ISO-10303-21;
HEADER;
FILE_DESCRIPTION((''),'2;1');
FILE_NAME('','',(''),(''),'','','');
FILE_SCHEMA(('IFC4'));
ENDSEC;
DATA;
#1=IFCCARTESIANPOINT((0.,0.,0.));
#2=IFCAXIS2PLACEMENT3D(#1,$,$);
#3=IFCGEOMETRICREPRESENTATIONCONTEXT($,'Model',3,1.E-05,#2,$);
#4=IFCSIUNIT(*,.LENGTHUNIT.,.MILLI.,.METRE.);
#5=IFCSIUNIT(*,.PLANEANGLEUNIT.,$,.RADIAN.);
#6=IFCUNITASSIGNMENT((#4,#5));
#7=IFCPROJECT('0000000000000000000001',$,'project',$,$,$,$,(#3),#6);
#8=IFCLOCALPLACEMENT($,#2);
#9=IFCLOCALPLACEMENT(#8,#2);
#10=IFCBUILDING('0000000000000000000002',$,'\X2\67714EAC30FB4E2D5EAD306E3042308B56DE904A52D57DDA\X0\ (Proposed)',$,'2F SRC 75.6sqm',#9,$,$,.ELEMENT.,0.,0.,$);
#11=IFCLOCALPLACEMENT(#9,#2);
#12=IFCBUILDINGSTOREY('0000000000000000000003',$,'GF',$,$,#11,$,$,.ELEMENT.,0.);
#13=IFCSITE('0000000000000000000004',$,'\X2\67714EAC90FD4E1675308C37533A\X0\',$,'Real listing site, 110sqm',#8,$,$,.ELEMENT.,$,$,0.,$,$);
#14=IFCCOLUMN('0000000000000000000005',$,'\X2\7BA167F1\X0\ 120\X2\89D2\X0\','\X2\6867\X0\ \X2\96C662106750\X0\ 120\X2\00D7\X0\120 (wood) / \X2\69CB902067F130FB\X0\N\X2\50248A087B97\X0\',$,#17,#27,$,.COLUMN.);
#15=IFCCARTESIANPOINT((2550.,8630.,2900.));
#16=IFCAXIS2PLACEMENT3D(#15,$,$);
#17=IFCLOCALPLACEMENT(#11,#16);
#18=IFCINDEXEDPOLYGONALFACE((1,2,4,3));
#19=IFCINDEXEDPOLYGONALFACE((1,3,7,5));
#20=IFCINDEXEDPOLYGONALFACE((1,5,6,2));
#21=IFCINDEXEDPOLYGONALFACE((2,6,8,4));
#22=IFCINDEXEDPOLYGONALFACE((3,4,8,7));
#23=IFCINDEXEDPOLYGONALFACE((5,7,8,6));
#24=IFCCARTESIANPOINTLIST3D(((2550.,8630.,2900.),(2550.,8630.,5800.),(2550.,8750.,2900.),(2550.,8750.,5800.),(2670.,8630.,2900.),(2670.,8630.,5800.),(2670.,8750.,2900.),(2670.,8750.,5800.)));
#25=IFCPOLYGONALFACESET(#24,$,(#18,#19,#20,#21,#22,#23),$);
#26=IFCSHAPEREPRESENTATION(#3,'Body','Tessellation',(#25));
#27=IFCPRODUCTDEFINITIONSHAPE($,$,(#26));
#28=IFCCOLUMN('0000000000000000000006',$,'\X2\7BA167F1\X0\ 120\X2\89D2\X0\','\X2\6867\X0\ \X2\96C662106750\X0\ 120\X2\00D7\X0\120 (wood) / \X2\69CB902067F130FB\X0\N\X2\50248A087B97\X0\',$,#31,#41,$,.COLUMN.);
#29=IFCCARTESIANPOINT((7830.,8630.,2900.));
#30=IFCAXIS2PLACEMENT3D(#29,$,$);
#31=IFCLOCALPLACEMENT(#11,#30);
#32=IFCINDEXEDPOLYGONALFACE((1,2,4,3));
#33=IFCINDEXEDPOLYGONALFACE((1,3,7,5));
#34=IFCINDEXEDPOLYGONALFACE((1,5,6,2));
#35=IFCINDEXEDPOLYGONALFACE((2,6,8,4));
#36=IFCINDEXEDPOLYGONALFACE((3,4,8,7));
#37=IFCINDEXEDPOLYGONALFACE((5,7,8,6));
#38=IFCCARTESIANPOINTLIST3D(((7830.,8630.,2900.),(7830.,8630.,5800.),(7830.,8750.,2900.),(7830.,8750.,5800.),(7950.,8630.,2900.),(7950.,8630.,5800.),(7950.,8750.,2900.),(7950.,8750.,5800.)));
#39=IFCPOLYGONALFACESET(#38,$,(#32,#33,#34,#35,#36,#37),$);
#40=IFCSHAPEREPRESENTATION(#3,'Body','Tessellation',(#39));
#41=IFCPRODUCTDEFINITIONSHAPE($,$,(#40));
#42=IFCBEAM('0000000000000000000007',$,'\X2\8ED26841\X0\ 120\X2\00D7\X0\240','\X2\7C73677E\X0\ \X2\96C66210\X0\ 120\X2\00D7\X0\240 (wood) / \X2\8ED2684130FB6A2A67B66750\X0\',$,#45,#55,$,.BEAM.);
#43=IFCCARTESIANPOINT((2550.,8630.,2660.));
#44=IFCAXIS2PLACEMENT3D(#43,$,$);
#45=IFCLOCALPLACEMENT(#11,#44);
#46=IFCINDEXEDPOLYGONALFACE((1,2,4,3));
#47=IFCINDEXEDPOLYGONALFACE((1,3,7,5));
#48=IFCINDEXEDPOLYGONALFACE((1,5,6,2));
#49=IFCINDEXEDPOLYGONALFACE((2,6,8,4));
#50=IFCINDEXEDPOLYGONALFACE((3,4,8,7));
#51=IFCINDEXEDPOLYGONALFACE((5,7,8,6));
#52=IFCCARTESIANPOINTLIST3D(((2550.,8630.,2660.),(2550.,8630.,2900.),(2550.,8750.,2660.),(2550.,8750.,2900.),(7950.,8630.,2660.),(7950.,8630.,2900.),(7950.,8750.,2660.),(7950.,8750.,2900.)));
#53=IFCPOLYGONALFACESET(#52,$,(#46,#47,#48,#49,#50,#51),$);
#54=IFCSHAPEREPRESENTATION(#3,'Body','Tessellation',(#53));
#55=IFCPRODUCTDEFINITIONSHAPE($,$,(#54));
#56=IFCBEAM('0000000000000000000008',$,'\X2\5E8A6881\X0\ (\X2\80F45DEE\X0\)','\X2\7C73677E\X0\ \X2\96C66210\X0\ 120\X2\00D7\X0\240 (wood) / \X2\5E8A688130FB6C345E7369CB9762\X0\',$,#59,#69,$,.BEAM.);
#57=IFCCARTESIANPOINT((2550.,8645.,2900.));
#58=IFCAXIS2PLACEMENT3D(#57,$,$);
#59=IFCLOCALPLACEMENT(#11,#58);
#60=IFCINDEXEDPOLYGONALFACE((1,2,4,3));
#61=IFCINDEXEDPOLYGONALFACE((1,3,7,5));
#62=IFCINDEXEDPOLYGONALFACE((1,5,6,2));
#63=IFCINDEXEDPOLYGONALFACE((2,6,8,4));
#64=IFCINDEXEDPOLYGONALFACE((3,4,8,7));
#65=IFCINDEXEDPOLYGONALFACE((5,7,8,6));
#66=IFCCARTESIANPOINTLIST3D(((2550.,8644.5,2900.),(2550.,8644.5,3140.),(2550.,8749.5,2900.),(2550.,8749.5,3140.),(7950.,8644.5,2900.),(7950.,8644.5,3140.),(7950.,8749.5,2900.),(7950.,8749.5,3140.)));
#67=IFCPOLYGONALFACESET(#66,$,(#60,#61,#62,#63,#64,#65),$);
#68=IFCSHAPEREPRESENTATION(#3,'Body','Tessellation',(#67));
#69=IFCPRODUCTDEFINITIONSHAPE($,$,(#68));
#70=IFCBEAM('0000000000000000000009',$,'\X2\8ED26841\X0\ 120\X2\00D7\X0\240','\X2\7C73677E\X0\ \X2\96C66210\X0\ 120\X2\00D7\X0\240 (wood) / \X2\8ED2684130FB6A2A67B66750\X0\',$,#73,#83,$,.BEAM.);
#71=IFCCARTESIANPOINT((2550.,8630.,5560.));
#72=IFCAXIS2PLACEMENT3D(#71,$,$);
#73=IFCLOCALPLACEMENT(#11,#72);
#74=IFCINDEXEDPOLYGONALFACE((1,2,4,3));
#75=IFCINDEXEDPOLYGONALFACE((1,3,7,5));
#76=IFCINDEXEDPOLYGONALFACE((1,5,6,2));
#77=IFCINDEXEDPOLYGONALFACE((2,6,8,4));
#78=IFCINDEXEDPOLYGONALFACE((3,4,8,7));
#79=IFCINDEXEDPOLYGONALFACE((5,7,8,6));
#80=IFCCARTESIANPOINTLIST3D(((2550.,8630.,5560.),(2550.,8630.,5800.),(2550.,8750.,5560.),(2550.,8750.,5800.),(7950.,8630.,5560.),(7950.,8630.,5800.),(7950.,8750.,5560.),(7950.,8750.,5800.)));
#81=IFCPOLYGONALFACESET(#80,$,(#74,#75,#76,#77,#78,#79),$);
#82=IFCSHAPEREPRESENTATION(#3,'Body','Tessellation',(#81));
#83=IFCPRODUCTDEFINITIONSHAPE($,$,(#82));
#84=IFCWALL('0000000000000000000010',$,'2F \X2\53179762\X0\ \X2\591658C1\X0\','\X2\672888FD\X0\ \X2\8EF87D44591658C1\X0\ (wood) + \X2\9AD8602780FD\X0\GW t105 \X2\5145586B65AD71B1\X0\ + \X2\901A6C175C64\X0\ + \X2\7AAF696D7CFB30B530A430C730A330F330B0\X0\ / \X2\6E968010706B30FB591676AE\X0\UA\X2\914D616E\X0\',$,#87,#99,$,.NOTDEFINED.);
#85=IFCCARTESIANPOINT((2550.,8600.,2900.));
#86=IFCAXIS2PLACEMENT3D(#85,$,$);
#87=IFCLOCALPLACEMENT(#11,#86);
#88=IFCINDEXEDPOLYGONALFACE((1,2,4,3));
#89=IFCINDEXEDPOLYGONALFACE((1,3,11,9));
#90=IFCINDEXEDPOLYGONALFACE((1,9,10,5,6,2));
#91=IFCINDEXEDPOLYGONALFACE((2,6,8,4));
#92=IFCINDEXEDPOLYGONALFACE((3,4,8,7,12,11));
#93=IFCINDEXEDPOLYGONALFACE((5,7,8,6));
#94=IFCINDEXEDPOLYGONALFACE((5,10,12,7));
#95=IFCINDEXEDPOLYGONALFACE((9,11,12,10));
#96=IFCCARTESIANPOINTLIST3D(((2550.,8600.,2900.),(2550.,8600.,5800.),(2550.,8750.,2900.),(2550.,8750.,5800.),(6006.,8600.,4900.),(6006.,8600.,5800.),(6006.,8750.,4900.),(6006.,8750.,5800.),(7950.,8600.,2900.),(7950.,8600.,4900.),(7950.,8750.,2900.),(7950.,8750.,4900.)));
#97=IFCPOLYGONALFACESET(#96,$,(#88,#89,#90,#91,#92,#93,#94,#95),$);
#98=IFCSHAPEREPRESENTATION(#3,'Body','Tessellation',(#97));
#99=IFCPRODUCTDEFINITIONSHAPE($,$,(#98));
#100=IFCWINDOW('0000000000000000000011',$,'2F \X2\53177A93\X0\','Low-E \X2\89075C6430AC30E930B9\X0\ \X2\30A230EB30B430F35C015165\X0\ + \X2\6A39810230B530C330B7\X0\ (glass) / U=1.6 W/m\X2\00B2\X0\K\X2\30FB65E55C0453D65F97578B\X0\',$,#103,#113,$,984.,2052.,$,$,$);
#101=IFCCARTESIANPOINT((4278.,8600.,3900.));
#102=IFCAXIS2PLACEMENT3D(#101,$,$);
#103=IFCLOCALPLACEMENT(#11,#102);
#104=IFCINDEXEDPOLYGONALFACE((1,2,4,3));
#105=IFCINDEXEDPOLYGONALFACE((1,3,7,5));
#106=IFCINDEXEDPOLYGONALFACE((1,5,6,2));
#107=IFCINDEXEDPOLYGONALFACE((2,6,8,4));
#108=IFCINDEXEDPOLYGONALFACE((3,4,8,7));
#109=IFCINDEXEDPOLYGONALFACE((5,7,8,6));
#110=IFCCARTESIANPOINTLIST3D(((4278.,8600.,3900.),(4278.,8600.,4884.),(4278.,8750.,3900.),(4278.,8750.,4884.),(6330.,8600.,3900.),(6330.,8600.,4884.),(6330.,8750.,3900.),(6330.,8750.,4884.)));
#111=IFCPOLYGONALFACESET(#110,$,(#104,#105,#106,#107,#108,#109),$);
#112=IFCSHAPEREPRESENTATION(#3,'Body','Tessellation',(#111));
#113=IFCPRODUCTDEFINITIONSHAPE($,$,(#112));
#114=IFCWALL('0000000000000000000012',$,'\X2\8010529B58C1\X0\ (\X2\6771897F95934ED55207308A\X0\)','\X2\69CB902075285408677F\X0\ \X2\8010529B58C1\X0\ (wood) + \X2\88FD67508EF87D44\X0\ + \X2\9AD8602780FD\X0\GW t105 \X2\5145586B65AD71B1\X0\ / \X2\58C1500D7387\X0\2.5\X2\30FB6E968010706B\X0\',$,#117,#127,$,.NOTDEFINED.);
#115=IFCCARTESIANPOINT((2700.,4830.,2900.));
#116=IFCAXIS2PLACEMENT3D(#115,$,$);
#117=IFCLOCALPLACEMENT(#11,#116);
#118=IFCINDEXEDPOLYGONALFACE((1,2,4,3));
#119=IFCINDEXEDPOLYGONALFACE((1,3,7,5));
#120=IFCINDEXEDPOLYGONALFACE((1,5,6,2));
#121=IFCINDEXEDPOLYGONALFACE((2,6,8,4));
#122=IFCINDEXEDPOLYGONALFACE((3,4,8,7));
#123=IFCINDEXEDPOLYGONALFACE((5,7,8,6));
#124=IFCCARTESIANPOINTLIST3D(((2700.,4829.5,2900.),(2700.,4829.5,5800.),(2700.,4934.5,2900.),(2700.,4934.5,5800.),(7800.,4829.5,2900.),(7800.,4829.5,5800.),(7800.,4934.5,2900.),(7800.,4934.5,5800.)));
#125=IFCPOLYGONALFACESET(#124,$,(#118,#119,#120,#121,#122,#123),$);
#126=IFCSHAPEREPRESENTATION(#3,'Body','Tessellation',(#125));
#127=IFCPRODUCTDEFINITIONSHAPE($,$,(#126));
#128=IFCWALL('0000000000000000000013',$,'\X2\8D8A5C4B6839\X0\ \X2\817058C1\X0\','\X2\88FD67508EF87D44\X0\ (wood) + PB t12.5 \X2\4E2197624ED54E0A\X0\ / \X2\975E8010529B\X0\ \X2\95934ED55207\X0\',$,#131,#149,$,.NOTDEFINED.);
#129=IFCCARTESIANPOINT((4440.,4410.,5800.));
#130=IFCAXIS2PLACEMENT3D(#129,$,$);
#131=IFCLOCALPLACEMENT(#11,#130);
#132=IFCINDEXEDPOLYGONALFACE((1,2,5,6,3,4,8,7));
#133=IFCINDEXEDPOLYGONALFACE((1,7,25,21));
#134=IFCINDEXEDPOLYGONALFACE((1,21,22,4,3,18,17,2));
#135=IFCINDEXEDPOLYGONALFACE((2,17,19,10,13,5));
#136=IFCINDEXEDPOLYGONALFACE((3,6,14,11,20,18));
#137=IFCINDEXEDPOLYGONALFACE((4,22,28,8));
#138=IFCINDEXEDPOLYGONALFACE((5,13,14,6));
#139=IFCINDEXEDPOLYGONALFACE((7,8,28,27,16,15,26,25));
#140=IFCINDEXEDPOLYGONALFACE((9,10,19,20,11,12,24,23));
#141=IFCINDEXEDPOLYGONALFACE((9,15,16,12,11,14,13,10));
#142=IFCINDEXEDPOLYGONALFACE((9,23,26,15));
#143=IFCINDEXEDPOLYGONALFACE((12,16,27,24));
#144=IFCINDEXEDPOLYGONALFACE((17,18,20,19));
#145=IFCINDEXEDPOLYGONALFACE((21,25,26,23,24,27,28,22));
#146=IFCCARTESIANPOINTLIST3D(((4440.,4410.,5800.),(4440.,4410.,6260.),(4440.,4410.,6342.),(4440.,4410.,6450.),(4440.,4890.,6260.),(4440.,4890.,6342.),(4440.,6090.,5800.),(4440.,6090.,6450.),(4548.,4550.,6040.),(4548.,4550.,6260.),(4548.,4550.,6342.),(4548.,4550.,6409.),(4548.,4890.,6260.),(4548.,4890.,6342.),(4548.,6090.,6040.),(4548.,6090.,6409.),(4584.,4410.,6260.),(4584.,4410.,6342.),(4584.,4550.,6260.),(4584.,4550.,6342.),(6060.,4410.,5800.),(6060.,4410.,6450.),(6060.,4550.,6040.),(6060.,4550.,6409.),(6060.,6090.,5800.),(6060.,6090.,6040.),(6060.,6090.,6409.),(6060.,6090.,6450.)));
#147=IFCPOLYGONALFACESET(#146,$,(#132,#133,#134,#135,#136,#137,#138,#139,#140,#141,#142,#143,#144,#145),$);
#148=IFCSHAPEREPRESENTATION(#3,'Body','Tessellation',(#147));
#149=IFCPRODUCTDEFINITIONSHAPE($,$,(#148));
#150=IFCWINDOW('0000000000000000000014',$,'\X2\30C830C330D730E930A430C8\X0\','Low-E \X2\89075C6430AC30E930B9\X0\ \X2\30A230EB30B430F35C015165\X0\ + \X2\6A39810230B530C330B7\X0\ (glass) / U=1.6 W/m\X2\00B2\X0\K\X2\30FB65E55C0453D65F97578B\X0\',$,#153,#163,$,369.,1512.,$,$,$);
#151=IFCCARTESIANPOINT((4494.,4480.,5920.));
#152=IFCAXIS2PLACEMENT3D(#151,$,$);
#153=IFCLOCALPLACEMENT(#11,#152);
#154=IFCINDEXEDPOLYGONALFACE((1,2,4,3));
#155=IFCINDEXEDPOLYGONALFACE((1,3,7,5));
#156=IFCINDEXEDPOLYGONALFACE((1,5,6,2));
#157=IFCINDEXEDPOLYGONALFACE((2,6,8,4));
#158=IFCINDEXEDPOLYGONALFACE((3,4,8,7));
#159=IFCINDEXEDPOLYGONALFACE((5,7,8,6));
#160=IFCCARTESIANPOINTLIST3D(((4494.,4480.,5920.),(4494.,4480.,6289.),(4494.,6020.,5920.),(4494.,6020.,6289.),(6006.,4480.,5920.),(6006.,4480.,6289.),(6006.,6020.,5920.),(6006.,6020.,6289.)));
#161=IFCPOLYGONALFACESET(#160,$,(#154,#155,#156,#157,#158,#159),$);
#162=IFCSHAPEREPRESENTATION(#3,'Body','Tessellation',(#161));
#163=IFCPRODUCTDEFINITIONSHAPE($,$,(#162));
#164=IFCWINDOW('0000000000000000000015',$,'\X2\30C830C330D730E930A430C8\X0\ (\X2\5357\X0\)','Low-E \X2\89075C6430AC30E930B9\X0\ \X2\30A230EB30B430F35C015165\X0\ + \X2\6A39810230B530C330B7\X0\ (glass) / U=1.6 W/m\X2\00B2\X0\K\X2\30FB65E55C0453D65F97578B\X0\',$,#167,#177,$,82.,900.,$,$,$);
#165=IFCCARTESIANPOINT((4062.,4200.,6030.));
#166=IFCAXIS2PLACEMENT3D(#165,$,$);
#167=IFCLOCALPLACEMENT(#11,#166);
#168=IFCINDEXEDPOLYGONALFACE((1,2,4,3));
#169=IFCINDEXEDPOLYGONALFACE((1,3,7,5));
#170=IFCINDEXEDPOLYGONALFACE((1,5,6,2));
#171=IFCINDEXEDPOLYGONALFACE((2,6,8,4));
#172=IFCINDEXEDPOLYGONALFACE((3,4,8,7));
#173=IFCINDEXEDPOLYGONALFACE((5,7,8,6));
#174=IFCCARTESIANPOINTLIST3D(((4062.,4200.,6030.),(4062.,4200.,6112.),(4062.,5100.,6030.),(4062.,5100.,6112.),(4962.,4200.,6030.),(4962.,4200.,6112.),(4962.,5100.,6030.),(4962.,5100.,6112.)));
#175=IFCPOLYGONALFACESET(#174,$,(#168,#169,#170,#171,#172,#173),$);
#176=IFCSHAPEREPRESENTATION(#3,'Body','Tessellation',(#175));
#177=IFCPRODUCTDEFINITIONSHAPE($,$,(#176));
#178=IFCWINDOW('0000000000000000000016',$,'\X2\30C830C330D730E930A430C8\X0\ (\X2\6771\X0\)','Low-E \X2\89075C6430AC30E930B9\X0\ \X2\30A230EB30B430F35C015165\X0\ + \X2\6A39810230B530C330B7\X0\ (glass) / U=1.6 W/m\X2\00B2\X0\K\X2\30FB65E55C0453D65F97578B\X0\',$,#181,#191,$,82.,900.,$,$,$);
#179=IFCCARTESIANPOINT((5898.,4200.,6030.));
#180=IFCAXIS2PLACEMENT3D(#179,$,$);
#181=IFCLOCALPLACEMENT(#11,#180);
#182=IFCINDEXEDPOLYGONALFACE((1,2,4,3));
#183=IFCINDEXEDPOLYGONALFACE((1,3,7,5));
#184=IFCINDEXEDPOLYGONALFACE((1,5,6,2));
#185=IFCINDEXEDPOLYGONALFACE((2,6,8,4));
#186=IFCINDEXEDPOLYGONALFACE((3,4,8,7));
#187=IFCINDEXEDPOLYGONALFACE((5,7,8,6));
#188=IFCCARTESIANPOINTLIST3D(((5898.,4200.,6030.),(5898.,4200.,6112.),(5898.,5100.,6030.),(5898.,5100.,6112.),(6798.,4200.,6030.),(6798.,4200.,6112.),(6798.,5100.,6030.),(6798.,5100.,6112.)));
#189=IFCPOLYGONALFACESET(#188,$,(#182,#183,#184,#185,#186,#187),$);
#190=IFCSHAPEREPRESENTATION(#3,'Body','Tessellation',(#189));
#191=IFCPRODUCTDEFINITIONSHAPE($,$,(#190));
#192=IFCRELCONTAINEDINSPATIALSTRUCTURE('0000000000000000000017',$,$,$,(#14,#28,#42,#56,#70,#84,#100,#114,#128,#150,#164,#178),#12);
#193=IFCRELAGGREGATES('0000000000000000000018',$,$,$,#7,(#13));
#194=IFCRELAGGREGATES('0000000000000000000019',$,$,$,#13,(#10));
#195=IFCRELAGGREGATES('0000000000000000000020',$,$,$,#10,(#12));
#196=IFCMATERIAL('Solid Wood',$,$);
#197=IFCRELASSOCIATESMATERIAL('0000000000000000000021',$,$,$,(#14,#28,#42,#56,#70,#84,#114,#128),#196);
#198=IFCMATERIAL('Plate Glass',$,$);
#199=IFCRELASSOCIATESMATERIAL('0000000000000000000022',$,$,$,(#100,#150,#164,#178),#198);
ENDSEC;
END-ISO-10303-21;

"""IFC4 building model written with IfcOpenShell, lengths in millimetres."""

from ifc_helpers import new_model, si_unit, frame, frame_2d, origin, place, context, project, spatial, rectangle, extrude, material, element, fill, save


model = new_model("IFC4")

# Units and contexts
model_context = context("Model", 3, precision=1e-05, world=origin())
ifc_project = project(units=[si_unit("LENGTHUNIT", "METRE", prefix="MILLI"), si_unit("PLANEANGLEUNIT", "RADIAN")], contexts=[model_context])

# Site, building, storey
site_placement = place(None, origin())
site = spatial("IfcSite", under=ifc_project, at=site_placement, Name="東京都世田谷区", ObjectType="Real listing site, 110sqm", CompositionType="ELEMENT", RefElevation=0.0)
building_placement = place(site_placement, origin())
building = spatial("IfcBuilding", under=site, at=building_placement, Name="東京・中庭のある回遊動線 (Proposed)", ObjectType="2F SRC 75.6sqm", CompositionType="ELEMENT", ElevationOfRefHeight=0.0, ElevationOfTerrain=0.0)
storey_placement = place(building_placement, origin())
storey = spatial("IfcBuildingStorey", under=building, at=storey_placement, Name="GF", CompositionType="ELEMENT", Elevation=0.0)

# Columns
ifc_material_1 = material(Name="Solid Wood")
column_1_placement = place(storey_placement, frame((2550.0, 8630.0, 2900.0)))
element("IfcColumn", 1, at=column_1_placement, inside=storey, material=ifc_material_1, Name="管柱 120角", Description="桧 集成材 120×120 (wood) / 構造柱・N値計算", PredefinedType="COLUMN", context=model_context, shape_type="SweptSolid", body=[
    extrude(rectangle(XDim=120.0, YDim=120.0, at=frame_2d((60.0, 60.0))), frame((2550.0, 8630.0, 2900.0)), (0.0, 0.0, 1.0), 2900.0),
])
column_2_placement = place(storey_placement, frame((7830.0, 8630.0, 2900.0)))
element("IfcColumn", 2, at=column_2_placement, inside=storey, material=ifc_material_1, Name="管柱 120角", Description="桧 集成材 120×120 (wood) / 構造柱・N値計算", PredefinedType="COLUMN", context=model_context, shape_type="SweptSolid", body=[
    extrude(rectangle(XDim=120.0, YDim=120.0, at=frame_2d((60.0, 60.0))), frame((7830.0, 8630.0, 2900.0)), (0.0, 0.0, 1.0), 2900.0),
])

# Beams
beam_1_placement = place(storey_placement, frame((2550.0, 8630.0, 2660.0)))
element("IfcBeam", 3, at=beam_1_placement, inside=storey, material=ifc_material_1, Name="軒桁 120×240", Description="米松 集成 120×240 (wood) / 軒桁・横架材", PredefinedType="BEAM", context=model_context, shape_type="SweptSolid", body=[
    extrude(rectangle(XDim=5400.0, YDim=120.0, at=frame_2d((2700.0, 60.0))), frame((2550.0, 8630.0, 2660.0)), (0.0, 0.0, 1.0), 240.0),
])
beam_2_placement = place(storey_placement, frame((2550.0, 8645.0, 2900.0)))
element("IfcBeam", 4, at=beam_2_placement, inside=storey, material=ifc_material_1, Name="床梁 (胴差)", Description="米松 集成 120×240 (wood) / 床梁・水平構面", PredefinedType="BEAM", context=model_context, shape_type="SweptSolid", body=[
    extrude(rectangle(XDim=5400.0, YDim=105.0, at=frame_2d((2700.0, 52.0))), frame((2550.0, 8645.0, 2900.0)), (0.0, 0.0, 1.0), 240.0),
])
beam_3_placement = place(storey_placement, frame((2550.0, 8630.0, 5560.0)))
element("IfcBeam", 5, at=beam_3_placement, inside=storey, material=ifc_material_1, Name="軒桁 120×240", Description="米松 集成 120×240 (wood) / 軒桁・横架材", PredefinedType="BEAM", context=model_context, shape_type="SweptSolid", body=[
    extrude(rectangle(XDim=5400.0, YDim=120.0, at=frame_2d((2700.0, 60.0))), frame((2550.0, 8630.0, 5560.0)), (0.0, 0.0, 1.0), 240.0),
])

# Wall, opening, window
wall_1_placement = place(storey_placement, frame((2550.0, 8600.0, 2900.0)))
wall_1 = element("IfcWall", 6, at=wall_1_placement, inside=storey, material=ifc_material_1, Name="2F 北面 外壁", Description="木製 軸組外壁 (wood) + 高性能GW t105 充填断熱 + 通気層 + 窯業系サイディング / 準耐火・外皮UA配慮", PredefinedType="NOTDEFINED", context=model_context, shape_type="SweptSolid", body=[
    extrude(rectangle(XDim=5400.0, YDim=150.0, at=frame_2d((2700.0, 75.0))), frame((2550.0, 8600.0, 2900.0)), (0.0, 0.0, 1.0), 2900.0),
])
opening_1_placement = place(storey_placement, frame((4278.0, 8600.0, 3900.0)))
opening_1 = element("IfcOpeningElement", 7, at=opening_1_placement, cuts=wall_1, PredefinedType="NOTDEFINED", context=model_context, shape_type="SweptSolid", body=[
    extrude(rectangle(XDim=2052.0, YDim=150.0, at=frame_2d((1026.0, 75.0))), frame((4278.0, 8600.0, 3900.0)), (0.0, 0.0, 1.0), 984.0),
])
ifc_material_2 = material(Name="Plate Glass")
window_1_placement = place(storey_placement, frame((4278.0, 8600.0, 3900.0)))
window_1 = element("IfcWindow", 8, at=window_1_placement, inside=storey, material=ifc_material_2, Name="2F 北窓", Description="Low-E 複層ガラス アルゴン封入 + 樹脂サッシ (glass) / U=1.6 W/m²K・日射取得型", OverallHeight=984.0, OverallWidth=2052.0, context=model_context, shape_type="SweptSolid", body=[
    extrude(rectangle(XDim=2052.0, YDim=150.0, at=frame_2d((1026.0, 75.0))), frame((4278.0, 8600.0, 3900.0)), (0.0, 0.0, 1.0), 984.0),
])
fill(opening_1, window_1)

# Wall
wall_2_placement = place(storey_placement, frame((2700.0, 4830.0, 2900.0)))
element("IfcWall", 9, at=wall_2_placement, inside=storey, material=ifc_material_1, Name="耐力壁 (東西間仕切り)", Description="構造用合板 耐力壁 (wood) + 製材軸組 + 高性能GW t105 充填断熱 / 壁倍率2.5・準耐火", PredefinedType="NOTDEFINED", context=model_context, shape_type="SweptSolid", body=[
    extrude(rectangle(XDim=5100.0, YDim=105.0, at=frame_2d((2550.0, 52.0))), frame((2700.0, 4830.0, 2900.0)), (0.0, 0.0, 1.0), 2900.0),
])

# Wall, openings, windows
wall_3_placement = place(storey_placement, frame((4440.0, 4410.0, 5800.0)))
wall_3 = element("IfcWall", 10, at=wall_3_placement, inside=storey, material=ifc_material_1, Name="越屋根 腰壁", Description="製材軸組 (wood) + PB t12.5 両面仕上 / 非耐力 間仕切", PredefinedType="NOTDEFINED", context=model_context, shape_type="SweptSolid", body=[
    extrude(rectangle(XDim=1620.0, YDim=1680.0, at=frame_2d((810.0, 840.0))), frame((4440.0, 4410.0, 5800.0)), (0.0, 0.0, 1.0), 650.0),
])
opening_2_placement = place(storey_placement, frame((4494.0, 4480.0, 5920.0)))
opening_2 = element("IfcOpeningElement", 11, at=opening_2_placement, cuts=wall_3, PredefinedType="NOTDEFINED", context=model_context, shape_type="SweptSolid", body=[
    extrude(rectangle(XDim=1512.0, YDim=1540.0, at=frame_2d((756.0, 770.0))), frame((4494.0, 4480.0, 5920.0)), (0.0, 0.0, 1.0), 369.0),
])
opening_3_placement = place(storey_placement, frame((4062.0, 4200.0, 6030.0)))
opening_3 = element("IfcOpeningElement", 12, at=opening_3_placement, cuts=wall_3, PredefinedType="NOTDEFINED", context=model_context, shape_type="SweptSolid", body=[
    extrude(rectangle(XDim=900.0, YDim=900.0, at=frame_2d((450.0, 450.0))), frame((4062.0, 4200.0, 6030.0)), (0.0, 0.0, 1.0), 82.0),
])
opening_4_placement = place(storey_placement, frame((5898.0, 4200.0, 6030.0)))
opening_4 = element("IfcOpeningElement", 13, at=opening_4_placement, cuts=wall_3, PredefinedType="NOTDEFINED", context=model_context, shape_type="SweptSolid", body=[
    extrude(rectangle(XDim=900.0, YDim=900.0, at=frame_2d((450.0, 450.0))), frame((5898.0, 4200.0, 6030.0)), (0.0, 0.0, 1.0), 82.0),
])
window_2_placement = place(storey_placement, frame((4494.0, 4480.0, 5920.0)))
window_2 = element("IfcWindow", 14, at=window_2_placement, inside=storey, material=ifc_material_2, Name="トップライト", Description="Low-E 複層ガラス アルゴン封入 + 樹脂サッシ (glass) / U=1.6 W/m²K・日射取得型", OverallHeight=369.0, OverallWidth=1512.0, context=model_context, shape_type="SweptSolid", body=[
    extrude(rectangle(XDim=1512.0, YDim=1540.0, at=frame_2d((756.0, 770.0))), frame((4494.0, 4480.0, 5920.0)), (0.0, 0.0, 1.0), 369.0),
])
fill(opening_2, window_2)
window_3_placement = place(storey_placement, frame((4062.0, 4200.0, 6030.0)))
window_3 = element("IfcWindow", 15, at=window_3_placement, inside=storey, material=ifc_material_2, Name="トップライト (南)", Description="Low-E 複層ガラス アルゴン封入 + 樹脂サッシ (glass) / U=1.6 W/m²K・日射取得型", OverallHeight=82.0, OverallWidth=900.0, context=model_context, shape_type="SweptSolid", body=[
    extrude(rectangle(XDim=900.0, YDim=900.0, at=frame_2d((450.0, 450.0))), frame((4062.0, 4200.0, 6030.0)), (0.0, 0.0, 1.0), 82.0),
])
fill(opening_3, window_3)
window_4_placement = place(storey_placement, frame((5898.0, 4200.0, 6030.0)))
window_4 = element("IfcWindow", 16, at=window_4_placement, inside=storey, material=ifc_material_2, Name="トップライト (東)", Description="Low-E 複層ガラス アルゴン封入 + 樹脂サッシ (glass) / U=1.6 W/m²K・日射取得型", OverallHeight=82.0, OverallWidth=900.0, context=model_context, shape_type="SweptSolid", body=[
    extrude(rectangle(XDim=900.0, YDim=900.0, at=frame_2d((450.0, 450.0))), frame((5898.0, 4200.0, 6030.0)), (0.0, 0.0, 1.0), 82.0),
])
fill(opening_4, window_4)

save(model, "model.ifc")
